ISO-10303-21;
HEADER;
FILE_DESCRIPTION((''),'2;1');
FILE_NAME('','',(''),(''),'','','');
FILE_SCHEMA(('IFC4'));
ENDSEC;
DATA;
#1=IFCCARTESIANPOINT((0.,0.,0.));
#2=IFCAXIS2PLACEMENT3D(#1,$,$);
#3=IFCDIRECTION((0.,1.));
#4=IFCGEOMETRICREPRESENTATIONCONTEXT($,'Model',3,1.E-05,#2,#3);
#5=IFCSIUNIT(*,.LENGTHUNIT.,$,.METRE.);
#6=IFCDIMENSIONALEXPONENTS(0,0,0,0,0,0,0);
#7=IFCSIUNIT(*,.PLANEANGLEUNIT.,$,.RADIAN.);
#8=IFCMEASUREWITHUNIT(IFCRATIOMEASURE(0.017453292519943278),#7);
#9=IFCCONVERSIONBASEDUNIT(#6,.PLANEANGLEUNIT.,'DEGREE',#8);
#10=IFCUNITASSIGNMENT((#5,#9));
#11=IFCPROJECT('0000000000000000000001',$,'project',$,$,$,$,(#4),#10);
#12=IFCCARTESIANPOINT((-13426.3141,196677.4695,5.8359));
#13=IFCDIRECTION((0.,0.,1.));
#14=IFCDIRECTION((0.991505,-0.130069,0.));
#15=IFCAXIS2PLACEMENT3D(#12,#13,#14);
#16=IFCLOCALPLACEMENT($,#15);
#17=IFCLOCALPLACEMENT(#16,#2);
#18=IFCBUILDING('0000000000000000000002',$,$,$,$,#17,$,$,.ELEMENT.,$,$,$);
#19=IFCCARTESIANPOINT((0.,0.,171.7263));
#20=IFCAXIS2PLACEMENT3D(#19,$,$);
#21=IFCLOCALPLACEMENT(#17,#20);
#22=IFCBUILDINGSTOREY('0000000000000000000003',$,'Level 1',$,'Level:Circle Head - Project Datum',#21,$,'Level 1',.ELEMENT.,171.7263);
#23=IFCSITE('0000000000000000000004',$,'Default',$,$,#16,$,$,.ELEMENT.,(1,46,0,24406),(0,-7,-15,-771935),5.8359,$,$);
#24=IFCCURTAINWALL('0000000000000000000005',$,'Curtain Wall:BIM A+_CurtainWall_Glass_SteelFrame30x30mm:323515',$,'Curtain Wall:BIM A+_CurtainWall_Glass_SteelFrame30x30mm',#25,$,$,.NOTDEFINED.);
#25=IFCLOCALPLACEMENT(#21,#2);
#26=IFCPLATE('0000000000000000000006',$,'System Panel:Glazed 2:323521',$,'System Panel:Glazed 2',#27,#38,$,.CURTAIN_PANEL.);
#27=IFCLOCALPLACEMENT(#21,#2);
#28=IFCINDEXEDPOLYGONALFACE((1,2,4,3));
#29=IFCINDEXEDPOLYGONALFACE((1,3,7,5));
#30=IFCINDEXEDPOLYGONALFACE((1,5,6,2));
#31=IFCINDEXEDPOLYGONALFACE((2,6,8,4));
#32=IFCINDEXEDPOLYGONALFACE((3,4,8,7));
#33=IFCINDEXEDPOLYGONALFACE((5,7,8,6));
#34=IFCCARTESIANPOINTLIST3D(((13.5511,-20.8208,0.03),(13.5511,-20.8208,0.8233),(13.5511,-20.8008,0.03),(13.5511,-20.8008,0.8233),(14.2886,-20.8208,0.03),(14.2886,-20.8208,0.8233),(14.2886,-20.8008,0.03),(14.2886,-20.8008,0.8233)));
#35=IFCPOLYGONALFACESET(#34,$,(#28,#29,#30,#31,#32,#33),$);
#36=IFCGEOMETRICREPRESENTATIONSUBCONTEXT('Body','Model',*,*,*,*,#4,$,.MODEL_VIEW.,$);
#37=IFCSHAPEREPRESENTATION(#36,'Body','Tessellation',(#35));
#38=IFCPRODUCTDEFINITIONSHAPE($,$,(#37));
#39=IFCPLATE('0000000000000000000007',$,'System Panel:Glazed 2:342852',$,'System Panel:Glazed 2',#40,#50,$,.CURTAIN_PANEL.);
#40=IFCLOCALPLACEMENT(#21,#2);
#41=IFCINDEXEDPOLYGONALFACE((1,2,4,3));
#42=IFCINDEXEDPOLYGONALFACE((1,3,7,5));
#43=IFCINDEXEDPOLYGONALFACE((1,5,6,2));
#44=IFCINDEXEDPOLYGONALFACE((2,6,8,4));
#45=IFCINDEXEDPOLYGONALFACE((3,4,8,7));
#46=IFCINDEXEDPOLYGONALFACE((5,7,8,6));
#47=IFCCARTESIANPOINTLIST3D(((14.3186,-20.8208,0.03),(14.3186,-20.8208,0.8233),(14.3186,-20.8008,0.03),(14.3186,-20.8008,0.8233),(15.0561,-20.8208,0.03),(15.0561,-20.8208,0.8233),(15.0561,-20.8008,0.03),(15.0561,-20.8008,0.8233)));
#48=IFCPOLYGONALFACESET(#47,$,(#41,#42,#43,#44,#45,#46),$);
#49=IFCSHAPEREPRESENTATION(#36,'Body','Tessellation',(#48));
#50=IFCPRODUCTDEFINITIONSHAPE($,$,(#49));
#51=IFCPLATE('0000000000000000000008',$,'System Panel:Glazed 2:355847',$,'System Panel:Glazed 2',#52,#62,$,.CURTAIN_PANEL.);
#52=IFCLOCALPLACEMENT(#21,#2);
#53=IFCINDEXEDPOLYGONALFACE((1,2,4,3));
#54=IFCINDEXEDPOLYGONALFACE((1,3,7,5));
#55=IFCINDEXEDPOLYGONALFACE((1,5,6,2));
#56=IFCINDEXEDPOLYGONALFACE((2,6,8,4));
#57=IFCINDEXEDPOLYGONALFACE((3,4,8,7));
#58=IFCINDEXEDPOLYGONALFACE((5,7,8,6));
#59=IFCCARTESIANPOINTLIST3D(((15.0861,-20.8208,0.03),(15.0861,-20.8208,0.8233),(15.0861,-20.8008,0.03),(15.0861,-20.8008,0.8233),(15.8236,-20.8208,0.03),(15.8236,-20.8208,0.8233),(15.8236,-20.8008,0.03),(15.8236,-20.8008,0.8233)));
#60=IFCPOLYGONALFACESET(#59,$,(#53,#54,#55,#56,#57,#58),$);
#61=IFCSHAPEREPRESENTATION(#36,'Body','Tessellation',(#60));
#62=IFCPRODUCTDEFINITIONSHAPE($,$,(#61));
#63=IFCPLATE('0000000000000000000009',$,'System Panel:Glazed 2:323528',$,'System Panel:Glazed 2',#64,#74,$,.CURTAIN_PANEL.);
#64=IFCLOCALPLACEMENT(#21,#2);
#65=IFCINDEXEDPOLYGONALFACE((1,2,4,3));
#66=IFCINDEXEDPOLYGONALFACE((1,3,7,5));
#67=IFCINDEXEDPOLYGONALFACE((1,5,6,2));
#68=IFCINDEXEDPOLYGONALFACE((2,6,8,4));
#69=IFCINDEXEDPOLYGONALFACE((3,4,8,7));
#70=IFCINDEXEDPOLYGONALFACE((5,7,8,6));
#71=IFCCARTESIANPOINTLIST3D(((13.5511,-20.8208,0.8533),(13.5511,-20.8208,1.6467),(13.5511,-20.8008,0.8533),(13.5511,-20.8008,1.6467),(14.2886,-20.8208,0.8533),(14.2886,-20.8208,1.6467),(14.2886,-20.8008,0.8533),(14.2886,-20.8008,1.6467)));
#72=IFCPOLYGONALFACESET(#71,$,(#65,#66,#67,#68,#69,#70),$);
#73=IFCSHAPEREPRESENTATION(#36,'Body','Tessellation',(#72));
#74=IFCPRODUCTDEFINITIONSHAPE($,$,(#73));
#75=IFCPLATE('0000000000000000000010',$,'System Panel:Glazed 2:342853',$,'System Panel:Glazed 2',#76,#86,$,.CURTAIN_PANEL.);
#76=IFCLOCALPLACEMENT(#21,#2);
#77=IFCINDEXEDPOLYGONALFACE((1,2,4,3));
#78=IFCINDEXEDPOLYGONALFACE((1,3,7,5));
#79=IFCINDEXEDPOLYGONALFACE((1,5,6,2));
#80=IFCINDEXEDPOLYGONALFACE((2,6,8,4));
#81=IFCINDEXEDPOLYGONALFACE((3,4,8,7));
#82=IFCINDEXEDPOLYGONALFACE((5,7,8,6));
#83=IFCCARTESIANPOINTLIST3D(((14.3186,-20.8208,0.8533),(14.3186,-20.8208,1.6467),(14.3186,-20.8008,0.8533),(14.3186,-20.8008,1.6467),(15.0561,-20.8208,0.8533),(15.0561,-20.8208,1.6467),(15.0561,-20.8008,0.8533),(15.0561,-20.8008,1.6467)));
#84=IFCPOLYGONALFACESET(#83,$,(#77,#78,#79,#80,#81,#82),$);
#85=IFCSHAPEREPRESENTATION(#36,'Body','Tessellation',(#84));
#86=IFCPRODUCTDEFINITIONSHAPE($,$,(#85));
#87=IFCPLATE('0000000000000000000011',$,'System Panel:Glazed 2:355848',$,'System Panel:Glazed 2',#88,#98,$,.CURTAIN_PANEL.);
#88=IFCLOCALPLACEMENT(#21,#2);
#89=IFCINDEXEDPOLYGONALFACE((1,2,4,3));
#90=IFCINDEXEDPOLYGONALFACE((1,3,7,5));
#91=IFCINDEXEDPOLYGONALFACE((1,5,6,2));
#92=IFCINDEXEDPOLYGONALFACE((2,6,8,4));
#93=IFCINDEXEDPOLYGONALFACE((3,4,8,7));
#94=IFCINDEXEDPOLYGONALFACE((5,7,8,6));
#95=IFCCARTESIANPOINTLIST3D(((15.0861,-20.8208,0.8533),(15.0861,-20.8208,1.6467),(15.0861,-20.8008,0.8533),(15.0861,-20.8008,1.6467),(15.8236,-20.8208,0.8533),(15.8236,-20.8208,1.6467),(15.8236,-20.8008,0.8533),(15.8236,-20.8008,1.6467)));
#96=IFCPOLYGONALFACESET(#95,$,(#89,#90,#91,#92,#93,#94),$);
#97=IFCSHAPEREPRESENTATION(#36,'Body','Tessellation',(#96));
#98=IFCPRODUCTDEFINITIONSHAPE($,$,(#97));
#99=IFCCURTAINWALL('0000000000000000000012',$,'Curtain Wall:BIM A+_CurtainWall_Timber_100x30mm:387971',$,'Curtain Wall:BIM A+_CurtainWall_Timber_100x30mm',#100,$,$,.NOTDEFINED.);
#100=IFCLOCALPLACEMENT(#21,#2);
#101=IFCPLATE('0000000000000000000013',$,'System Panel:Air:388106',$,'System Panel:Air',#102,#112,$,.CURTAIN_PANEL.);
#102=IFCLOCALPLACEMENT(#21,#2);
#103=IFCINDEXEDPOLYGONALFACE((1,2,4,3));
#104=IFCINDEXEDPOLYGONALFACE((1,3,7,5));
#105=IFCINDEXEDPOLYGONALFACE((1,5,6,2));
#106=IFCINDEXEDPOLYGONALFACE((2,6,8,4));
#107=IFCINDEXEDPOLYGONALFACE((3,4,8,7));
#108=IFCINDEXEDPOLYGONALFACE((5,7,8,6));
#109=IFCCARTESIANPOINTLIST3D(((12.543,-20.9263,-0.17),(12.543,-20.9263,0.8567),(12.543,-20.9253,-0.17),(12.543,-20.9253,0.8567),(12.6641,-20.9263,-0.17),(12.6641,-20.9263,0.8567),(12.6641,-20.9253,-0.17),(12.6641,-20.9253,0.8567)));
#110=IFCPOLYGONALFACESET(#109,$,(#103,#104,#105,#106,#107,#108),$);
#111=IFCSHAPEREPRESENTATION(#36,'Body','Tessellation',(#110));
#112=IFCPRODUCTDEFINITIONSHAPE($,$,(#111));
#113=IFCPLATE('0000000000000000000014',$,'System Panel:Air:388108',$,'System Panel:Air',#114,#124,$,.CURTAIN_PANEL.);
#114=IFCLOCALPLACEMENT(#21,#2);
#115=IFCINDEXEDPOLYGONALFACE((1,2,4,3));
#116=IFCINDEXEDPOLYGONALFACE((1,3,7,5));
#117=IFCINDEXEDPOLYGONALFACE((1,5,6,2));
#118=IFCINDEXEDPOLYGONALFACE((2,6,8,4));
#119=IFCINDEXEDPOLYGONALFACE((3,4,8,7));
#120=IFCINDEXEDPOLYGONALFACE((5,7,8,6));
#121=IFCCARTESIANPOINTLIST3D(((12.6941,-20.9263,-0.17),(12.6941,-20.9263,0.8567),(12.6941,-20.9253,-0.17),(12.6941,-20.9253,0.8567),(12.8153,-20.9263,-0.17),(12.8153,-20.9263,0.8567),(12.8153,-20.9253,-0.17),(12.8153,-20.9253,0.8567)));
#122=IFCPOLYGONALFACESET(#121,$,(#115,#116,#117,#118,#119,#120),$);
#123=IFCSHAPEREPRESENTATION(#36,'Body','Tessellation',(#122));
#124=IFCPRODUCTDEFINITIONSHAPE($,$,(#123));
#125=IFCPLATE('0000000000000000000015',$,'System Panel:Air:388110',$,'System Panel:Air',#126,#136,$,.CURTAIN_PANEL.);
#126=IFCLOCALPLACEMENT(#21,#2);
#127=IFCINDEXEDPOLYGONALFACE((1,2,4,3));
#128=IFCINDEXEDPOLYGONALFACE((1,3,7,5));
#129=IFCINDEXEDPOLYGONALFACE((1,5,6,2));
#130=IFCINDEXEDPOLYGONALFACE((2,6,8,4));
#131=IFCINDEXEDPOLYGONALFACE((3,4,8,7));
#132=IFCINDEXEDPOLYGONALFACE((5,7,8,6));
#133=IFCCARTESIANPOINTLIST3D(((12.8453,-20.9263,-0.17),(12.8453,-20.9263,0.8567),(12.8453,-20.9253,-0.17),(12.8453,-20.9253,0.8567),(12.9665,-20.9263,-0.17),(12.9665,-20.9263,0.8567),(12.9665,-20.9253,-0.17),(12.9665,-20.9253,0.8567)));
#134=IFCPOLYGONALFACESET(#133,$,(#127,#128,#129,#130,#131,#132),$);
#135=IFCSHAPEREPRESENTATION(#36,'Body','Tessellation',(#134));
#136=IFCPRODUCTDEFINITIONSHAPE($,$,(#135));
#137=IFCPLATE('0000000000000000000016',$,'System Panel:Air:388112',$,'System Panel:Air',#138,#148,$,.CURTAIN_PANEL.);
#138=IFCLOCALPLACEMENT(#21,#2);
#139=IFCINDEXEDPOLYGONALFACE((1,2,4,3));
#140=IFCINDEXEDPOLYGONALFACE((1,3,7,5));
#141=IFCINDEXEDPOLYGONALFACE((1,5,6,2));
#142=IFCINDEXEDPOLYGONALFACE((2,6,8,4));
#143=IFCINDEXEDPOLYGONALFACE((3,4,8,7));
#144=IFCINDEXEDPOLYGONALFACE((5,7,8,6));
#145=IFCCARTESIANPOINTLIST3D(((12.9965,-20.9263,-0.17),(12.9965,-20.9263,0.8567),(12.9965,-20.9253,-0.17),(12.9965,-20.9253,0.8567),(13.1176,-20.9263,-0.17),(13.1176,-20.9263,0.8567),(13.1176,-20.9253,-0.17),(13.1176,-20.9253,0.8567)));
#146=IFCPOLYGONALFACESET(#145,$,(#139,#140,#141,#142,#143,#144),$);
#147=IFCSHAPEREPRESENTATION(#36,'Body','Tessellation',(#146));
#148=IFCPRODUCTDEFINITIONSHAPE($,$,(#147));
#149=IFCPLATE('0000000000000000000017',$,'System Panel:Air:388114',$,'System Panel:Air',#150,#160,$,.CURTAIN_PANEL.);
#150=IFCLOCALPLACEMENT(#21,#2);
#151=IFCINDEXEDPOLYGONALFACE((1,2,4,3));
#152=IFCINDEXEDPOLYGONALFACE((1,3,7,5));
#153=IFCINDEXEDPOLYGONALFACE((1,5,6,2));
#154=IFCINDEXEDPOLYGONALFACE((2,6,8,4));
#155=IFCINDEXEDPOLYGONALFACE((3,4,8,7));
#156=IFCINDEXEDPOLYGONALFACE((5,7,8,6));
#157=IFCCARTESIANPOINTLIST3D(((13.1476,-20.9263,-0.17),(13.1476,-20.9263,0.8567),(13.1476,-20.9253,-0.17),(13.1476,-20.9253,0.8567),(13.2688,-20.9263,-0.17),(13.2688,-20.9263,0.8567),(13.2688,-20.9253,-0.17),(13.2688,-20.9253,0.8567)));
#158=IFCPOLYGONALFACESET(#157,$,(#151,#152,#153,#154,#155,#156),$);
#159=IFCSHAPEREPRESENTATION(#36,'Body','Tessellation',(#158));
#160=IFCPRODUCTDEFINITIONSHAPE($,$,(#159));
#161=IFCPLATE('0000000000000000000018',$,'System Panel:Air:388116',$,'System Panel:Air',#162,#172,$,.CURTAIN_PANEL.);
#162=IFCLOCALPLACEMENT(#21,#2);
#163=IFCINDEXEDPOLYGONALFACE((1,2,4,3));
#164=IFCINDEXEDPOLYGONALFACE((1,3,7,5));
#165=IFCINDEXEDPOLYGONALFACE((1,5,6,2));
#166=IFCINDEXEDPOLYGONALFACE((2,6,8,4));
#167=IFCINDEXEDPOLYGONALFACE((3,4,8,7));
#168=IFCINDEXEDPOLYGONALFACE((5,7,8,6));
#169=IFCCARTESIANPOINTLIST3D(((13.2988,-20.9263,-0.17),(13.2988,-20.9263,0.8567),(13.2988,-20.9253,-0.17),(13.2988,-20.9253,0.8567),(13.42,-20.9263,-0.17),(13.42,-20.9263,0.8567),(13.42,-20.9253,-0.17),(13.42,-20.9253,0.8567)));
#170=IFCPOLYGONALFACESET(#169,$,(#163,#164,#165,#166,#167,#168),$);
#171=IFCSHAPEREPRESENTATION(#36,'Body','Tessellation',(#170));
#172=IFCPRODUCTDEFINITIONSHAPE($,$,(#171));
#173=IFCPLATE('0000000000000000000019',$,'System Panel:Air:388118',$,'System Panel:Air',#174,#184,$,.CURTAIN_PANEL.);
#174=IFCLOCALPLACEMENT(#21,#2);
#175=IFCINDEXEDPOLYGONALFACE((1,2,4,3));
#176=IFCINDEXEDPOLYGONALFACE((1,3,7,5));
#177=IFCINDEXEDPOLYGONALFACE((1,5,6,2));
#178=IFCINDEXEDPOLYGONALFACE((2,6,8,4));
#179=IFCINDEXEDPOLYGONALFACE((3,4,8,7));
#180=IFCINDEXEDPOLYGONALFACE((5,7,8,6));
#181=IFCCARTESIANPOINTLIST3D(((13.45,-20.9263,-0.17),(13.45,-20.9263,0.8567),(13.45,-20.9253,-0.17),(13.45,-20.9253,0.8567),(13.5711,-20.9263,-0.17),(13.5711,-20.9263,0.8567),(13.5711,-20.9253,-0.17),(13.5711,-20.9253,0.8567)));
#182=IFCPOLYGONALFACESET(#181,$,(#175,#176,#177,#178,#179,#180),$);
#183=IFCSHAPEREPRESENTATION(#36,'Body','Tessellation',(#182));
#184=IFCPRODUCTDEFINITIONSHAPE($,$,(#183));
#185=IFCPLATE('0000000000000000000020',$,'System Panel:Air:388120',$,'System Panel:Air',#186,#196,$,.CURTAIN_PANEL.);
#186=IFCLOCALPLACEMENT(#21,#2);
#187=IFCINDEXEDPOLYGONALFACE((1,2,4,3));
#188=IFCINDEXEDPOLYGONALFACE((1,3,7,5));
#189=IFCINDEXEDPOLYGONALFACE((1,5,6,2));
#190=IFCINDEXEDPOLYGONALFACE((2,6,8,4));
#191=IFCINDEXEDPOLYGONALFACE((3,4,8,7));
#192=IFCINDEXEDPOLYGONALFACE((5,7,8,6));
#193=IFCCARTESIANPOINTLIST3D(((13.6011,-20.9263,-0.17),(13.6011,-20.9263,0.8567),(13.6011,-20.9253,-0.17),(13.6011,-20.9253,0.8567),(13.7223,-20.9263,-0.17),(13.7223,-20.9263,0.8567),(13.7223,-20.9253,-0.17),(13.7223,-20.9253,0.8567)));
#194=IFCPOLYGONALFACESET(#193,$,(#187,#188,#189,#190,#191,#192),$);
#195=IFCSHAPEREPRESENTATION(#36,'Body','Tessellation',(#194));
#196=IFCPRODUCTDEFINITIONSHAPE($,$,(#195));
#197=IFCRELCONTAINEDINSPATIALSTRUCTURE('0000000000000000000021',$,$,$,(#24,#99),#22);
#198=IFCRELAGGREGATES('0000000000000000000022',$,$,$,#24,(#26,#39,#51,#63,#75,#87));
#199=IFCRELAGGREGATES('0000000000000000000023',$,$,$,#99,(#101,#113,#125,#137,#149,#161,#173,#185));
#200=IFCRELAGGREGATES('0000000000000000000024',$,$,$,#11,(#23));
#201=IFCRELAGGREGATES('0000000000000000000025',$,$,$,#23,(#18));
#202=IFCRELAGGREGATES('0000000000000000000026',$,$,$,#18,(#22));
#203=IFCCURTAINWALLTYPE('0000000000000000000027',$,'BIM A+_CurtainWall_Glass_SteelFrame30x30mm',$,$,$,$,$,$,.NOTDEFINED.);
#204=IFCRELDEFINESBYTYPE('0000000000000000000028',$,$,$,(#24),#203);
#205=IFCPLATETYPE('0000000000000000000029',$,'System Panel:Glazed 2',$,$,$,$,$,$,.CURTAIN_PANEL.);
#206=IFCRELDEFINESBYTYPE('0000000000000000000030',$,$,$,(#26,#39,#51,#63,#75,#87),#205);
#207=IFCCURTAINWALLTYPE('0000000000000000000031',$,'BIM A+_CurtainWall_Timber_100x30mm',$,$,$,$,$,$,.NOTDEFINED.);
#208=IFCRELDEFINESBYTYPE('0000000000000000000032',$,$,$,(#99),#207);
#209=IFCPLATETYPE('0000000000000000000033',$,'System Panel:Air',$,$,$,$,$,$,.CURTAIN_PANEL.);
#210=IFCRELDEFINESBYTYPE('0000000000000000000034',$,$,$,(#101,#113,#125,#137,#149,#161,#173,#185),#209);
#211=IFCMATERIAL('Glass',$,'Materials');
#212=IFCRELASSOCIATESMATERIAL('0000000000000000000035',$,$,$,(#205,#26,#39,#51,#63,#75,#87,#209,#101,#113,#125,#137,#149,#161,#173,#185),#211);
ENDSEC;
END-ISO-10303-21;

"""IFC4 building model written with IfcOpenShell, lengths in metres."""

from ifc_helpers import new_model, entity, si_unit, converted_unit, direction, frame, origin, place, context, subcontext, project, spatial, indexed_curve, outline, extrude, source, transform, mapped, material, type_object, type_shapes, element, aggregate, save


model = new_model("IFC4")

# Units and contexts
model_context = context("Model", 3, precision=1e-05, world=origin(), true_north=direction((0.0, 1.0)))
body_context = subcontext(model_context, "Body", "Model", "MODEL_VIEW")
ifc_project = project(units=[si_unit("LENGTHUNIT", "METRE"), converted_unit("PLANEANGLEUNIT", "DEGREE", entity("IfcRatioMeasure", 0.017453292519943278), si_unit("PLANEANGLEUNIT", "RADIAN"), dimensions=[0, 0, 0, 0, 0, 0, 0])], contexts=[model_context])

# Site, building, storey
site_placement = place(None, frame((-13426.3141, 196677.4695, 5.8359), z_axis=(0.0, 0.0, 1.0), x_axis=(0.991505, -0.130069, 0.0)))
site = spatial("IfcSite", under=ifc_project, at=site_placement, Name="Default", CompositionType="ELEMENT", RefLatitude=(1, 46, 0, 24406), RefLongitude=(0, -7, -15, -771935), RefElevation=5.8359)
building_placement = place(site_placement, origin())
building = spatial("IfcBuilding", under=site, at=building_placement, CompositionType="ELEMENT")
storey_placement = place(building_placement, frame((0.0, 0.0, 171.7263)))
storey = spatial("IfcBuildingStorey", under=building, at=storey_placement, Name="Level 1", ObjectType="Level:Circle Head - Project Datum", LongName="Level 1", CompositionType="ELEMENT", Elevation=171.7263)

# Curtain wall, plates
curtain_wall_type_1 = type_object("IfcCurtainWallType", Name="BIM A+_CurtainWall_Glass_SteelFrame30x30mm", PredefinedType="NOTDEFINED")
curtain_wall_1_placement = place(storey_placement, frame((0.0, 0.0, -171.7263)))
curtain_wall_1 = element("IfcCurtainWall", 1, at=curtain_wall_1_placement, inside=storey, type_object=curtain_wall_type_1, Name="Curtain Wall:BIM A+_CurtainWall_Glass_SteelFrame30x30mm:323515", ObjectType="Curtain Wall:BIM A+_CurtainWall_Glass_SteelFrame30x30mm", PredefinedType="NOTDEFINED")
ifc_material_1 = material(Name="Glass", Category="Materials")
plate_type_1 = type_object("IfcPlateType", Name="System Panel:Glazed 2", PredefinedType="CURTAIN_PANEL", material=ifc_material_1)
shared_shape_1 = source(origin(), body_context, "Body", "SweptSolid", [
    extrude(outline(indexed_curve([(-0.01, -0.3688), (0.01, -0.3688), (0.01, 0.3688), (-0.01, 0.3688), (-0.01, -0.3688)], self_intersect=False)), frame((0.0, 0.0, 0.0), z_axis=(0.0, 0.0, 1.0), x_axis=(0.0, 1.0, 0.0)), (0.0, 0.0, 1.0), 0.7933),
])
type_shapes(plate_type_1, [shared_shape_1])
plate_1_placement = place(curtain_wall_1_placement, frame((13.9198, -20.8108, 171.7563)))
plate_1 = element("IfcPlate", 2, at=plate_1_placement, type_object=plate_type_1, material=ifc_material_1, Name="System Panel:Glazed 2:323521", ObjectType="System Panel:Glazed 2", PredefinedType="CURTAIN_PANEL", context=body_context, shape_type="MappedRepresentation", body=[
    mapped(shared_shape_1, transform((0.0, 0.0, 0.0), scale=1.0)),
])
plate_2_placement = place(curtain_wall_1_placement, frame((14.6873, -20.8108, 171.7563)))
plate_2 = element("IfcPlate", 3, at=plate_2_placement, type_object=plate_type_1, material=ifc_material_1, Name="System Panel:Glazed 2:342852", ObjectType="System Panel:Glazed 2", PredefinedType="CURTAIN_PANEL", context=body_context, shape_type="MappedRepresentation", body=[
    mapped(shared_shape_1, transform((0.0, 0.0, 0.0), scale=1.0)),
])
plate_3_placement = place(curtain_wall_1_placement, frame((15.4548, -20.8108, 171.7563)))
plate_3 = element("IfcPlate", 4, at=plate_3_placement, type_object=plate_type_1, material=ifc_material_1, Name="System Panel:Glazed 2:355847", ObjectType="System Panel:Glazed 2", PredefinedType="CURTAIN_PANEL", context=body_context, shape_type="MappedRepresentation", body=[
    mapped(shared_shape_1, transform((0.0, 0.0, 0.0), scale=1.0)),
])
plate_4_placement = place(curtain_wall_1_placement, frame((13.9198, -20.8108, 172.5796)))
plate_4 = element("IfcPlate", 5, at=plate_4_placement, type_object=plate_type_1, material=ifc_material_1, Name="System Panel:Glazed 2:323528", ObjectType="System Panel:Glazed 2", PredefinedType="CURTAIN_PANEL", context=body_context, shape_type="MappedRepresentation", body=[
    mapped(shared_shape_1, transform((0.0, 0.0, 0.0), scale=1.0)),
])
plate_5_placement = place(curtain_wall_1_placement, frame((14.6873, -20.8108, 172.5796)))
plate_5 = element("IfcPlate", 6, at=plate_5_placement, type_object=plate_type_1, material=ifc_material_1, Name="System Panel:Glazed 2:342853", ObjectType="System Panel:Glazed 2", PredefinedType="CURTAIN_PANEL", context=body_context, shape_type="MappedRepresentation", body=[
    mapped(shared_shape_1, transform((0.0, 0.0, 0.0), scale=1.0)),
])
plate_6_placement = place(curtain_wall_1_placement, frame((15.4548, -20.8108, 172.5796)))
plate_6 = element("IfcPlate", 7, at=plate_6_placement, type_object=plate_type_1, material=ifc_material_1, Name="System Panel:Glazed 2:355848", ObjectType="System Panel:Glazed 2", PredefinedType="CURTAIN_PANEL", context=body_context, shape_type="MappedRepresentation", body=[
    mapped(shared_shape_1, transform((0.0, 0.0, 0.0), scale=1.0)),
])
aggregate(curtain_wall_1, [plate_1, plate_2, plate_3, plate_4, plate_5, plate_6])

# Curtain wall, plates
curtain_wall_type_2 = type_object("IfcCurtainWallType", Name="BIM A+_CurtainWall_Timber_100x30mm", PredefinedType="NOTDEFINED")
curtain_wall_2_placement = place(storey_placement, frame((0.0, 0.0, -171.7263)))
curtain_wall_2 = element("IfcCurtainWall", 8, at=curtain_wall_2_placement, inside=storey, type_object=curtain_wall_type_2, Name="Curtain Wall:BIM A+_CurtainWall_Timber_100x30mm:387971", ObjectType="Curtain Wall:BIM A+_CurtainWall_Timber_100x30mm", PredefinedType="NOTDEFINED")
plate_type_2 = type_object("IfcPlateType", Name="System Panel:Air", PredefinedType="CURTAIN_PANEL", material=ifc_material_1)
shared_shape_2 = source(origin(), body_context, "Body", "SweptSolid", [
    extrude(outline(indexed_curve([(-0.0005, -0.0606), (0.0005, -0.0606), (0.0005, 0.0606), (-0.0005, 0.0606), (-0.0005, -0.0606)], self_intersect=False)), frame((0.0, 0.0, 0.0), z_axis=(0.0, 0.0, 1.0), x_axis=(0.0, 1.0, 0.0)), (0.0, 0.0, 1.0), 1.0267),
])
type_shapes(plate_type_2, [shared_shape_2])
plate_7_placement = place(curtain_wall_2_placement, frame((12.6036, -20.9258, 171.5563)))
plate_7 = element("IfcPlate", 9, at=plate_7_placement, type_object=plate_type_2, material=ifc_material_1, Name="System Panel:Air:388106", ObjectType="System Panel:Air", PredefinedType="CURTAIN_PANEL", context=body_context, shape_type="MappedRepresentation", body=[
    mapped(shared_shape_2, transform((0.0, 0.0, 0.0), scale=1.0)),
])
plate_8_placement = place(curtain_wall_2_placement, frame((12.7547, -20.9258, 171.5563)))
plate_8 = element("IfcPlate", 10, at=plate_8_placement, type_object=plate_type_2, material=ifc_material_1, Name="System Panel:Air:388108", ObjectType="System Panel:Air", PredefinedType="CURTAIN_PANEL", context=body_context, shape_type="MappedRepresentation", body=[
    mapped(shared_shape_2, transform((0.0, 0.0, 0.0), scale=1.0)),
])
plate_9_placement = place(curtain_wall_2_placement, frame((12.9059, -20.9258, 171.5563)))
plate_9 = element("IfcPlate", 11, at=plate_9_placement, type_object=plate_type_2, material=ifc_material_1, Name="System Panel:Air:388110", ObjectType="System Panel:Air", PredefinedType="CURTAIN_PANEL", context=body_context, shape_type="MappedRepresentation", body=[
    mapped(shared_shape_2, transform((0.0, 0.0, 0.0), scale=1.0)),
])
plate_10_placement = place(curtain_wall_2_placement, frame((13.057, -20.9258, 171.5563)))
plate_10 = element("IfcPlate", 12, at=plate_10_placement, type_object=plate_type_2, material=ifc_material_1, Name="System Panel:Air:388112", ObjectType="System Panel:Air", PredefinedType="CURTAIN_PANEL", context=body_context, shape_type="MappedRepresentation", body=[
    mapped(shared_shape_2, transform((0.0, 0.0, 0.0), scale=1.0)),
])
plate_11_placement = place(curtain_wall_2_placement, frame((13.2082, -20.9258, 171.5563)))
plate_11 = element("IfcPlate", 13, at=plate_11_placement, type_object=plate_type_2, material=ifc_material_1, Name="System Panel:Air:388114", ObjectType="System Panel:Air", PredefinedType="CURTAIN_PANEL", context=body_context, shape_type="MappedRepresentation", body=[
    mapped(shared_shape_2, transform((0.0, 0.0, 0.0), scale=1.0)),
])
plate_12_placement = place(curtain_wall_2_placement, frame((13.3594, -20.9258, 171.5563)))
plate_12 = element("IfcPlate", 14, at=plate_12_placement, type_object=plate_type_2, material=ifc_material_1, Name="System Panel:Air:388116", ObjectType="System Panel:Air", PredefinedType="CURTAIN_PANEL", context=body_context, shape_type="MappedRepresentation", body=[
    mapped(shared_shape_2, transform((0.0, 0.0, 0.0), scale=1.0)),
])
plate_13_placement = place(curtain_wall_2_placement, frame((13.5105, -20.9258, 171.5563)))
plate_13 = element("IfcPlate", 15, at=plate_13_placement, type_object=plate_type_2, material=ifc_material_1, Name="System Panel:Air:388118", ObjectType="System Panel:Air", PredefinedType="CURTAIN_PANEL", context=body_context, shape_type="MappedRepresentation", body=[
    mapped(shared_shape_2, transform((0.0, 0.0, 0.0), scale=1.0)),
])
plate_14_placement = place(curtain_wall_2_placement, frame((13.6617, -20.9258, 171.5563)))
plate_14 = element("IfcPlate", 16, at=plate_14_placement, type_object=plate_type_2, material=ifc_material_1, Name="System Panel:Air:388120", ObjectType="System Panel:Air", PredefinedType="CURTAIN_PANEL", context=body_context, shape_type="MappedRepresentation", body=[
    mapped(shared_shape_2, transform((0.0, 0.0, 0.0), scale=1.0)),
])
aggregate(curtain_wall_2, [plate_7, plate_8, plate_9, plate_10, plate_11, plate_12, plate_13, plate_14])

save(model, "model.ifc")
